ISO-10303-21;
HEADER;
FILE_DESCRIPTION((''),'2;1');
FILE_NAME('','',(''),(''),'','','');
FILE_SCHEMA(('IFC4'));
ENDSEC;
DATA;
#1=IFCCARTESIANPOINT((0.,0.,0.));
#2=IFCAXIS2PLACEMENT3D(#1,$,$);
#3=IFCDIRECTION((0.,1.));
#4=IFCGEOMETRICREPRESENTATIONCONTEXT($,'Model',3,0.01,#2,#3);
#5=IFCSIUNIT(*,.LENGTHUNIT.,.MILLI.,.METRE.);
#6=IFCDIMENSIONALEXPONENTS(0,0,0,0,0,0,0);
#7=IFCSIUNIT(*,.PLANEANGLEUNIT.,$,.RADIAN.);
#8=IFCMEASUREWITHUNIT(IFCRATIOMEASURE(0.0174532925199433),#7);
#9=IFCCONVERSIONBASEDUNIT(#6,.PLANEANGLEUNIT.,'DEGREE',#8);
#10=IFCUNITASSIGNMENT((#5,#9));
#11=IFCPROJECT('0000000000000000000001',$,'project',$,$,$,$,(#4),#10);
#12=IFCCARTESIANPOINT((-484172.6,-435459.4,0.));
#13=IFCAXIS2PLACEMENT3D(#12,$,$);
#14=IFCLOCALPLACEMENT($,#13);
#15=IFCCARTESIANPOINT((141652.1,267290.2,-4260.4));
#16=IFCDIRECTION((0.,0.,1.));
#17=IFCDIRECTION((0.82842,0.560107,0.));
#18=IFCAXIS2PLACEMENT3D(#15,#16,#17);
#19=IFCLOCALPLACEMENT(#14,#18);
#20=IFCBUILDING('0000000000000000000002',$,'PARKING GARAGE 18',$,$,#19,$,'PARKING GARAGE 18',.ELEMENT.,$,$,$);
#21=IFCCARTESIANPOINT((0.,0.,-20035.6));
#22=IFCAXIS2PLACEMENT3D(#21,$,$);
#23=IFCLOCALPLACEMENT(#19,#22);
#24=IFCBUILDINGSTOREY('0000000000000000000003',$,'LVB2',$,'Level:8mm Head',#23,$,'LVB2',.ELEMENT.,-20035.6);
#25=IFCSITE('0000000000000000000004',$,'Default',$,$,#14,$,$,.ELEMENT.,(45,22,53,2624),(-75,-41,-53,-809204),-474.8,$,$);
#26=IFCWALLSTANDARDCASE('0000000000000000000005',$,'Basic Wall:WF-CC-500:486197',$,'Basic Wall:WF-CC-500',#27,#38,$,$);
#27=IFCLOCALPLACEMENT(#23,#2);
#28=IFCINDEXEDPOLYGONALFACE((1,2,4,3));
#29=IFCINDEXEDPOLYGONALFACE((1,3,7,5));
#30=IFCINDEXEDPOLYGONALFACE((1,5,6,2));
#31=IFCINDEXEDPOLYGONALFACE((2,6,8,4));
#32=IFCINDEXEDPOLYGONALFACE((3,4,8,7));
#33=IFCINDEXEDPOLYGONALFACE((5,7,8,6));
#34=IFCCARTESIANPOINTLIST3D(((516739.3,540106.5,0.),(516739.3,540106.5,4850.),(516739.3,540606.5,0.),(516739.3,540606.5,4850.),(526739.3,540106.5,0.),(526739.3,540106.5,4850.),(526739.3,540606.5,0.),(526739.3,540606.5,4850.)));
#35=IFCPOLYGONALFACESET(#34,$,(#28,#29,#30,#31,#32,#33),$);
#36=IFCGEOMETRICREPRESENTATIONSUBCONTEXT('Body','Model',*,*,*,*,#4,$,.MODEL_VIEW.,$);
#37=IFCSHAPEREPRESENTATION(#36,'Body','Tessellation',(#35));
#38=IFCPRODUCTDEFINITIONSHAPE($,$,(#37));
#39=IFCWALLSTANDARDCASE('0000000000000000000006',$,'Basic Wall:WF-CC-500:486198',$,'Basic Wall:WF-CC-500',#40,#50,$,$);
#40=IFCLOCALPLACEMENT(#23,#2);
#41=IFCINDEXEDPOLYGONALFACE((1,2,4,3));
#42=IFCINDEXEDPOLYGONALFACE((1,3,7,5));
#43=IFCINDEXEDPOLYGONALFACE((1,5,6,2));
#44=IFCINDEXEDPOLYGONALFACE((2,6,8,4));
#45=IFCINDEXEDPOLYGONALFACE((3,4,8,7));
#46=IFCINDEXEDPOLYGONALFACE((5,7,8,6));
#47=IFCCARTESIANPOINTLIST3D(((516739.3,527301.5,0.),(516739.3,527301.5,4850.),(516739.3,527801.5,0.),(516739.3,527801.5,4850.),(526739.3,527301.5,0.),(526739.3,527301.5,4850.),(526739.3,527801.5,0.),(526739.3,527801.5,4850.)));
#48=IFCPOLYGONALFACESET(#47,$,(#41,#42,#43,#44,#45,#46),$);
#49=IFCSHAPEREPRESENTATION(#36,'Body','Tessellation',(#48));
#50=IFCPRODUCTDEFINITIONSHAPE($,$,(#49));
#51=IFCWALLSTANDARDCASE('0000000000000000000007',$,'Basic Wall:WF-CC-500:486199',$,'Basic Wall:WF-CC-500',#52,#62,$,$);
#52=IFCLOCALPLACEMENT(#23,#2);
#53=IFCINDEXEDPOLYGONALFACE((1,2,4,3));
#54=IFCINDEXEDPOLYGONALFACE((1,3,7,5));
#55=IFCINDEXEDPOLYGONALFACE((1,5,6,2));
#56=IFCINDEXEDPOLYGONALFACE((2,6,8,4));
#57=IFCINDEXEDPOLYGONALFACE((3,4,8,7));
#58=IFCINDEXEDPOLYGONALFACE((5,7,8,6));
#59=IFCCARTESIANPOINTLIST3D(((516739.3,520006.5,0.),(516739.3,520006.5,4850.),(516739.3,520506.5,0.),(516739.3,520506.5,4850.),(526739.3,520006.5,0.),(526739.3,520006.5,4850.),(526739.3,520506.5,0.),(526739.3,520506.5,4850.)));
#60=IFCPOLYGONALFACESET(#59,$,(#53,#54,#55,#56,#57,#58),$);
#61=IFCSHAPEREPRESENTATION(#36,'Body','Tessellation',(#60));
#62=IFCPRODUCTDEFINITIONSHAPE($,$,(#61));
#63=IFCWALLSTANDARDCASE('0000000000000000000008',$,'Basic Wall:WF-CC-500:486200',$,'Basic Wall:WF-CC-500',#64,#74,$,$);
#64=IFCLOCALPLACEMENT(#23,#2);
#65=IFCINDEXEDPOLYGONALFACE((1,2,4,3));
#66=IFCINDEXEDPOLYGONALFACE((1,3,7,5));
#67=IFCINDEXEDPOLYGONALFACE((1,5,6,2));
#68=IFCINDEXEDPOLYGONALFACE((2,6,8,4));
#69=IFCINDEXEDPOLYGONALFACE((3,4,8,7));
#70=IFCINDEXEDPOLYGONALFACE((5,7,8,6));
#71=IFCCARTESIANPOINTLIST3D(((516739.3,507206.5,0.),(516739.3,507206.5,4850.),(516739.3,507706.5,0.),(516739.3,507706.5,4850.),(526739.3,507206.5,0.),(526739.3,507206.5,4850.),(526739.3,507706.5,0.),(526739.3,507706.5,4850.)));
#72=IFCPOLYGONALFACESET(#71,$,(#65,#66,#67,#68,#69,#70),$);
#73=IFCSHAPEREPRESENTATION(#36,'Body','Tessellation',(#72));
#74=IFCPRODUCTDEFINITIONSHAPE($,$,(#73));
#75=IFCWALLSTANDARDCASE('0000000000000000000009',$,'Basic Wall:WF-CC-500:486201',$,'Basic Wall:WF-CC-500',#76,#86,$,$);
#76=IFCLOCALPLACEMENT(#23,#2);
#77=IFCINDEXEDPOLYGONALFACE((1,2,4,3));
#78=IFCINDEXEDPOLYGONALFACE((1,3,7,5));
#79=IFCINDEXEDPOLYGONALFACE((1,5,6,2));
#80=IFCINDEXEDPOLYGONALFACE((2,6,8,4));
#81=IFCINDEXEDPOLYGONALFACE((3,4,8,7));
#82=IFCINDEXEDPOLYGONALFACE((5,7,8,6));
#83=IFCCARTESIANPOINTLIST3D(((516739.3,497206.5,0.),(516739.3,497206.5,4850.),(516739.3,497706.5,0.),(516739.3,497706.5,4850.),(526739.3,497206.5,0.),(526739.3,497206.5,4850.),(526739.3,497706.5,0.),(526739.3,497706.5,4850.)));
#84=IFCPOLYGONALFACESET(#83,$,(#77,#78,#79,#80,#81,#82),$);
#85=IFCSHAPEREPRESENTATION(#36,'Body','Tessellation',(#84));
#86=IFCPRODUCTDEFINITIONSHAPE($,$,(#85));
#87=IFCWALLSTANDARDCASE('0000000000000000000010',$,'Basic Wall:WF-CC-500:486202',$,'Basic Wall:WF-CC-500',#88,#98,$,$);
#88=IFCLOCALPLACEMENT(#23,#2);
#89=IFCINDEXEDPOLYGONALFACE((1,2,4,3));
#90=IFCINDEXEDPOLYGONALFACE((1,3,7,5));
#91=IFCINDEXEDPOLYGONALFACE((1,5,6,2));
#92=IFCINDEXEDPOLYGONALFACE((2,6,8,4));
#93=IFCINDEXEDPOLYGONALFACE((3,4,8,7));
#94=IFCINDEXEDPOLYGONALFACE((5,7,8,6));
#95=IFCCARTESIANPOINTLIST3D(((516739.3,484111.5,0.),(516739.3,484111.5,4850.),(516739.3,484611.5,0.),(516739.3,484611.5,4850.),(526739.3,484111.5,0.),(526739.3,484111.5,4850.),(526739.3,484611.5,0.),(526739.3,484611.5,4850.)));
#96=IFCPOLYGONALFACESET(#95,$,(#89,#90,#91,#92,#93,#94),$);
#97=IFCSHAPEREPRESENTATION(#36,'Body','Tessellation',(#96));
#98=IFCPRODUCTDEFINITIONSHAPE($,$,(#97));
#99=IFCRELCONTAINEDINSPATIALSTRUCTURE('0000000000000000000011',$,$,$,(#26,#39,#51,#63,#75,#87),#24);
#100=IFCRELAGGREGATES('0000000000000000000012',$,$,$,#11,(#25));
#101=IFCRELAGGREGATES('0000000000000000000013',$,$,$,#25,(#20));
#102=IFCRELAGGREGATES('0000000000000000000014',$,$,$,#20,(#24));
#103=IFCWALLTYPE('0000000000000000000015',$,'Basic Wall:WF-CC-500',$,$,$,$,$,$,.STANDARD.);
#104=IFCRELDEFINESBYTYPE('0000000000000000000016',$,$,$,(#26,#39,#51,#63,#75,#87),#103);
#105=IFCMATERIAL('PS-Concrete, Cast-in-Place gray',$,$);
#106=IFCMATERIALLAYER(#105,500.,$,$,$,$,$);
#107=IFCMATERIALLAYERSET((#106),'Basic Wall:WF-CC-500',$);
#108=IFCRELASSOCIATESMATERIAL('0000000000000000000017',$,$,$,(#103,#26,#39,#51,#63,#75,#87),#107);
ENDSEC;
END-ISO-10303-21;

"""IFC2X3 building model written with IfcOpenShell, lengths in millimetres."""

from ifc_helpers import new_model, entity, si_unit, converted_unit, direction, frame, frame_2d, origin, place, context, subcontext, project, spatial, rectangle, extrude, material, layer, layer_set, layer_usage, type_object, element, save


model = new_model("IFC2X3")

# Units and contexts
model_context = context("Model", 3, precision=0.01, world=origin(), true_north=direction((0.0, 1.0)))
body_context = subcontext(model_context, "Body", "Model", "MODEL_VIEW")
ifc_project = project(units=[si_unit("LENGTHUNIT", "METRE", prefix="MILLI"), converted_unit("PLANEANGLEUNIT", "DEGREE", entity("IfcRatioMeasure", 0.0174532925199433), si_unit("PLANEANGLEUNIT", "RADIAN"), dimensions=[0, 0, 0, 0, 0, 0, 0])], contexts=[model_context])

# Site, building, storey
site_placement = place(None, frame((-484172.6, -435459.4, 0.0)))
site = spatial("IfcSite", under=ifc_project, at=site_placement, Name="Default", CompositionType="ELEMENT", RefLatitude=(45, 22, 53, 2624), RefLongitude=(-75, -41, -53, -809204), RefElevation=-474.8)
building_placement = place(site_placement, frame((141652.1, 267290.2, -4260.4), z_axis=(0.0, 0.0, 1.0), x_axis=(0.82842, 0.560107, 0.0)))
building = spatial("IfcBuilding", under=site, at=building_placement, Name="PARKING GARAGE 18", LongName="PARKING GARAGE 18", CompositionType="ELEMENT")
storey_placement = place(building_placement, frame((0.0, 0.0, -20035.6)))
storey = spatial("IfcBuildingStorey", under=building, at=storey_placement, Name="LVB2", ObjectType="Level:8mm Head", LongName="LVB2", CompositionType="ELEMENT", Elevation=-20035.6)

# Walls
ifc_material = material(Name="PS-Concrete, Cast-in-Place gray")
ifc_layer = layer(ifc_material, 500.0)
ifc_layer_set = layer_set([ifc_layer], Name="Basic Wall:WF-CC-500")
wall_type = type_object("IfcWallType", Name="Basic Wall:WF-CC-500", PredefinedType="STANDARD", material=ifc_layer_set)
ifc_layer_usage_1 = layer_usage(ifc_layer_set, "AXIS2", "NEGATIVE", 250.0)
wall_1_placement = place(storey_placement, frame((516739.3, 540356.5, 0.0)))
element("IfcWallStandardCase", 1, at=wall_1_placement, inside=storey, type_object=wall_type, material=ifc_layer_usage_1, Name="Basic Wall:WF-CC-500:486197", ObjectType="Basic Wall:WF-CC-500", context=body_context, shape_type="SweptSolid", body=[
    extrude(rectangle(XDim=10000.0, YDim=500.0, at=frame_2d((5000.0, 0.0), x_axis=(-1.0, 0.0))), origin(), (0.0, 0.0, 1.0), 4850.0),
])
ifc_layer_usage_2 = layer_usage(ifc_layer_set, "AXIS2", "NEGATIVE", 250.0)
wall_2_placement = place(storey_placement, frame((516739.3, 527551.5, 0.0)))
element("IfcWallStandardCase", 2, at=wall_2_placement, inside=storey, type_object=wall_type, material=ifc_layer_usage_2, Name="Basic Wall:WF-CC-500:486198", ObjectType="Basic Wall:WF-CC-500", context=body_context, shape_type="SweptSolid", body=[
    extrude(rectangle(XDim=10000.0, YDim=500.0, at=frame_2d((5000.0, 0.0), x_axis=(-1.0, 0.0))), origin(), (0.0, 0.0, 1.0), 4850.0),
])
ifc_layer_usage_3 = layer_usage(ifc_layer_set, "AXIS2", "NEGATIVE", 250.0)
wall_3_placement = place(storey_placement, frame((516739.3, 520256.5, 0.0)))
element("IfcWallStandardCase", 3, at=wall_3_placement, inside=storey, type_object=wall_type, material=ifc_layer_usage_3, Name="Basic Wall:WF-CC-500:486199", ObjectType="Basic Wall:WF-CC-500", context=body_context, shape_type="SweptSolid", body=[
    extrude(rectangle(XDim=10000.0, YDim=500.0, at=frame_2d((5000.0, 0.0), x_axis=(-1.0, 0.0))), origin(), (0.0, 0.0, 1.0), 4850.0),
])
ifc_layer_usage_4 = layer_usage(ifc_layer_set, "AXIS2", "NEGATIVE", 250.0)
wall_4_placement = place(storey_placement, frame((516739.3, 507456.5, 0.0)))
element("IfcWallStandardCase", 4, at=wall_4_placement, inside=storey, type_object=wall_type, material=ifc_layer_usage_4, Name="Basic Wall:WF-CC-500:486200", ObjectType="Basic Wall:WF-CC-500", context=body_context, shape_type="SweptSolid", body=[
    extrude(rectangle(XDim=10000.0, YDim=500.0, at=frame_2d((5000.0, 0.0), x_axis=(-1.0, 0.0))), origin(), (0.0, 0.0, 1.0), 4850.0),
])
ifc_layer_usage_5 = layer_usage(ifc_layer_set, "AXIS2", "NEGATIVE", 250.0)
wall_5_placement = place(storey_placement, frame((516739.3, 497456.5, 0.0)))
element("IfcWallStandardCase", 5, at=wall_5_placement, inside=storey, type_object=wall_type, material=ifc_layer_usage_5, Name="Basic Wall:WF-CC-500:486201", ObjectType="Basic Wall:WF-CC-500", context=body_context, shape_type="SweptSolid", body=[
    extrude(rectangle(XDim=10000.0, YDim=500.0, at=frame_2d((5000.0, 0.0), x_axis=(-1.0, 0.0))), origin(), (0.0, 0.0, 1.0), 4850.0),
])
ifc_layer_usage_6 = layer_usage(ifc_layer_set, "AXIS2", "NEGATIVE", 250.0)
wall_6_placement = place(storey_placement, frame((516739.3, 484361.5, 0.0)))
element("IfcWallStandardCase", 6, at=wall_6_placement, inside=storey, type_object=wall_type, material=ifc_layer_usage_6, Name="Basic Wall:WF-CC-500:486202", ObjectType="Basic Wall:WF-CC-500", context=body_context, shape_type="SweptSolid", body=[
    extrude(rectangle(XDim=10000.0, YDim=500.0, at=frame_2d((5000.0, 0.0), x_axis=(-1.0, 0.0))), origin(), (0.0, 0.0, 1.0), 4850.0),
])

save(model, "model.ifc")
